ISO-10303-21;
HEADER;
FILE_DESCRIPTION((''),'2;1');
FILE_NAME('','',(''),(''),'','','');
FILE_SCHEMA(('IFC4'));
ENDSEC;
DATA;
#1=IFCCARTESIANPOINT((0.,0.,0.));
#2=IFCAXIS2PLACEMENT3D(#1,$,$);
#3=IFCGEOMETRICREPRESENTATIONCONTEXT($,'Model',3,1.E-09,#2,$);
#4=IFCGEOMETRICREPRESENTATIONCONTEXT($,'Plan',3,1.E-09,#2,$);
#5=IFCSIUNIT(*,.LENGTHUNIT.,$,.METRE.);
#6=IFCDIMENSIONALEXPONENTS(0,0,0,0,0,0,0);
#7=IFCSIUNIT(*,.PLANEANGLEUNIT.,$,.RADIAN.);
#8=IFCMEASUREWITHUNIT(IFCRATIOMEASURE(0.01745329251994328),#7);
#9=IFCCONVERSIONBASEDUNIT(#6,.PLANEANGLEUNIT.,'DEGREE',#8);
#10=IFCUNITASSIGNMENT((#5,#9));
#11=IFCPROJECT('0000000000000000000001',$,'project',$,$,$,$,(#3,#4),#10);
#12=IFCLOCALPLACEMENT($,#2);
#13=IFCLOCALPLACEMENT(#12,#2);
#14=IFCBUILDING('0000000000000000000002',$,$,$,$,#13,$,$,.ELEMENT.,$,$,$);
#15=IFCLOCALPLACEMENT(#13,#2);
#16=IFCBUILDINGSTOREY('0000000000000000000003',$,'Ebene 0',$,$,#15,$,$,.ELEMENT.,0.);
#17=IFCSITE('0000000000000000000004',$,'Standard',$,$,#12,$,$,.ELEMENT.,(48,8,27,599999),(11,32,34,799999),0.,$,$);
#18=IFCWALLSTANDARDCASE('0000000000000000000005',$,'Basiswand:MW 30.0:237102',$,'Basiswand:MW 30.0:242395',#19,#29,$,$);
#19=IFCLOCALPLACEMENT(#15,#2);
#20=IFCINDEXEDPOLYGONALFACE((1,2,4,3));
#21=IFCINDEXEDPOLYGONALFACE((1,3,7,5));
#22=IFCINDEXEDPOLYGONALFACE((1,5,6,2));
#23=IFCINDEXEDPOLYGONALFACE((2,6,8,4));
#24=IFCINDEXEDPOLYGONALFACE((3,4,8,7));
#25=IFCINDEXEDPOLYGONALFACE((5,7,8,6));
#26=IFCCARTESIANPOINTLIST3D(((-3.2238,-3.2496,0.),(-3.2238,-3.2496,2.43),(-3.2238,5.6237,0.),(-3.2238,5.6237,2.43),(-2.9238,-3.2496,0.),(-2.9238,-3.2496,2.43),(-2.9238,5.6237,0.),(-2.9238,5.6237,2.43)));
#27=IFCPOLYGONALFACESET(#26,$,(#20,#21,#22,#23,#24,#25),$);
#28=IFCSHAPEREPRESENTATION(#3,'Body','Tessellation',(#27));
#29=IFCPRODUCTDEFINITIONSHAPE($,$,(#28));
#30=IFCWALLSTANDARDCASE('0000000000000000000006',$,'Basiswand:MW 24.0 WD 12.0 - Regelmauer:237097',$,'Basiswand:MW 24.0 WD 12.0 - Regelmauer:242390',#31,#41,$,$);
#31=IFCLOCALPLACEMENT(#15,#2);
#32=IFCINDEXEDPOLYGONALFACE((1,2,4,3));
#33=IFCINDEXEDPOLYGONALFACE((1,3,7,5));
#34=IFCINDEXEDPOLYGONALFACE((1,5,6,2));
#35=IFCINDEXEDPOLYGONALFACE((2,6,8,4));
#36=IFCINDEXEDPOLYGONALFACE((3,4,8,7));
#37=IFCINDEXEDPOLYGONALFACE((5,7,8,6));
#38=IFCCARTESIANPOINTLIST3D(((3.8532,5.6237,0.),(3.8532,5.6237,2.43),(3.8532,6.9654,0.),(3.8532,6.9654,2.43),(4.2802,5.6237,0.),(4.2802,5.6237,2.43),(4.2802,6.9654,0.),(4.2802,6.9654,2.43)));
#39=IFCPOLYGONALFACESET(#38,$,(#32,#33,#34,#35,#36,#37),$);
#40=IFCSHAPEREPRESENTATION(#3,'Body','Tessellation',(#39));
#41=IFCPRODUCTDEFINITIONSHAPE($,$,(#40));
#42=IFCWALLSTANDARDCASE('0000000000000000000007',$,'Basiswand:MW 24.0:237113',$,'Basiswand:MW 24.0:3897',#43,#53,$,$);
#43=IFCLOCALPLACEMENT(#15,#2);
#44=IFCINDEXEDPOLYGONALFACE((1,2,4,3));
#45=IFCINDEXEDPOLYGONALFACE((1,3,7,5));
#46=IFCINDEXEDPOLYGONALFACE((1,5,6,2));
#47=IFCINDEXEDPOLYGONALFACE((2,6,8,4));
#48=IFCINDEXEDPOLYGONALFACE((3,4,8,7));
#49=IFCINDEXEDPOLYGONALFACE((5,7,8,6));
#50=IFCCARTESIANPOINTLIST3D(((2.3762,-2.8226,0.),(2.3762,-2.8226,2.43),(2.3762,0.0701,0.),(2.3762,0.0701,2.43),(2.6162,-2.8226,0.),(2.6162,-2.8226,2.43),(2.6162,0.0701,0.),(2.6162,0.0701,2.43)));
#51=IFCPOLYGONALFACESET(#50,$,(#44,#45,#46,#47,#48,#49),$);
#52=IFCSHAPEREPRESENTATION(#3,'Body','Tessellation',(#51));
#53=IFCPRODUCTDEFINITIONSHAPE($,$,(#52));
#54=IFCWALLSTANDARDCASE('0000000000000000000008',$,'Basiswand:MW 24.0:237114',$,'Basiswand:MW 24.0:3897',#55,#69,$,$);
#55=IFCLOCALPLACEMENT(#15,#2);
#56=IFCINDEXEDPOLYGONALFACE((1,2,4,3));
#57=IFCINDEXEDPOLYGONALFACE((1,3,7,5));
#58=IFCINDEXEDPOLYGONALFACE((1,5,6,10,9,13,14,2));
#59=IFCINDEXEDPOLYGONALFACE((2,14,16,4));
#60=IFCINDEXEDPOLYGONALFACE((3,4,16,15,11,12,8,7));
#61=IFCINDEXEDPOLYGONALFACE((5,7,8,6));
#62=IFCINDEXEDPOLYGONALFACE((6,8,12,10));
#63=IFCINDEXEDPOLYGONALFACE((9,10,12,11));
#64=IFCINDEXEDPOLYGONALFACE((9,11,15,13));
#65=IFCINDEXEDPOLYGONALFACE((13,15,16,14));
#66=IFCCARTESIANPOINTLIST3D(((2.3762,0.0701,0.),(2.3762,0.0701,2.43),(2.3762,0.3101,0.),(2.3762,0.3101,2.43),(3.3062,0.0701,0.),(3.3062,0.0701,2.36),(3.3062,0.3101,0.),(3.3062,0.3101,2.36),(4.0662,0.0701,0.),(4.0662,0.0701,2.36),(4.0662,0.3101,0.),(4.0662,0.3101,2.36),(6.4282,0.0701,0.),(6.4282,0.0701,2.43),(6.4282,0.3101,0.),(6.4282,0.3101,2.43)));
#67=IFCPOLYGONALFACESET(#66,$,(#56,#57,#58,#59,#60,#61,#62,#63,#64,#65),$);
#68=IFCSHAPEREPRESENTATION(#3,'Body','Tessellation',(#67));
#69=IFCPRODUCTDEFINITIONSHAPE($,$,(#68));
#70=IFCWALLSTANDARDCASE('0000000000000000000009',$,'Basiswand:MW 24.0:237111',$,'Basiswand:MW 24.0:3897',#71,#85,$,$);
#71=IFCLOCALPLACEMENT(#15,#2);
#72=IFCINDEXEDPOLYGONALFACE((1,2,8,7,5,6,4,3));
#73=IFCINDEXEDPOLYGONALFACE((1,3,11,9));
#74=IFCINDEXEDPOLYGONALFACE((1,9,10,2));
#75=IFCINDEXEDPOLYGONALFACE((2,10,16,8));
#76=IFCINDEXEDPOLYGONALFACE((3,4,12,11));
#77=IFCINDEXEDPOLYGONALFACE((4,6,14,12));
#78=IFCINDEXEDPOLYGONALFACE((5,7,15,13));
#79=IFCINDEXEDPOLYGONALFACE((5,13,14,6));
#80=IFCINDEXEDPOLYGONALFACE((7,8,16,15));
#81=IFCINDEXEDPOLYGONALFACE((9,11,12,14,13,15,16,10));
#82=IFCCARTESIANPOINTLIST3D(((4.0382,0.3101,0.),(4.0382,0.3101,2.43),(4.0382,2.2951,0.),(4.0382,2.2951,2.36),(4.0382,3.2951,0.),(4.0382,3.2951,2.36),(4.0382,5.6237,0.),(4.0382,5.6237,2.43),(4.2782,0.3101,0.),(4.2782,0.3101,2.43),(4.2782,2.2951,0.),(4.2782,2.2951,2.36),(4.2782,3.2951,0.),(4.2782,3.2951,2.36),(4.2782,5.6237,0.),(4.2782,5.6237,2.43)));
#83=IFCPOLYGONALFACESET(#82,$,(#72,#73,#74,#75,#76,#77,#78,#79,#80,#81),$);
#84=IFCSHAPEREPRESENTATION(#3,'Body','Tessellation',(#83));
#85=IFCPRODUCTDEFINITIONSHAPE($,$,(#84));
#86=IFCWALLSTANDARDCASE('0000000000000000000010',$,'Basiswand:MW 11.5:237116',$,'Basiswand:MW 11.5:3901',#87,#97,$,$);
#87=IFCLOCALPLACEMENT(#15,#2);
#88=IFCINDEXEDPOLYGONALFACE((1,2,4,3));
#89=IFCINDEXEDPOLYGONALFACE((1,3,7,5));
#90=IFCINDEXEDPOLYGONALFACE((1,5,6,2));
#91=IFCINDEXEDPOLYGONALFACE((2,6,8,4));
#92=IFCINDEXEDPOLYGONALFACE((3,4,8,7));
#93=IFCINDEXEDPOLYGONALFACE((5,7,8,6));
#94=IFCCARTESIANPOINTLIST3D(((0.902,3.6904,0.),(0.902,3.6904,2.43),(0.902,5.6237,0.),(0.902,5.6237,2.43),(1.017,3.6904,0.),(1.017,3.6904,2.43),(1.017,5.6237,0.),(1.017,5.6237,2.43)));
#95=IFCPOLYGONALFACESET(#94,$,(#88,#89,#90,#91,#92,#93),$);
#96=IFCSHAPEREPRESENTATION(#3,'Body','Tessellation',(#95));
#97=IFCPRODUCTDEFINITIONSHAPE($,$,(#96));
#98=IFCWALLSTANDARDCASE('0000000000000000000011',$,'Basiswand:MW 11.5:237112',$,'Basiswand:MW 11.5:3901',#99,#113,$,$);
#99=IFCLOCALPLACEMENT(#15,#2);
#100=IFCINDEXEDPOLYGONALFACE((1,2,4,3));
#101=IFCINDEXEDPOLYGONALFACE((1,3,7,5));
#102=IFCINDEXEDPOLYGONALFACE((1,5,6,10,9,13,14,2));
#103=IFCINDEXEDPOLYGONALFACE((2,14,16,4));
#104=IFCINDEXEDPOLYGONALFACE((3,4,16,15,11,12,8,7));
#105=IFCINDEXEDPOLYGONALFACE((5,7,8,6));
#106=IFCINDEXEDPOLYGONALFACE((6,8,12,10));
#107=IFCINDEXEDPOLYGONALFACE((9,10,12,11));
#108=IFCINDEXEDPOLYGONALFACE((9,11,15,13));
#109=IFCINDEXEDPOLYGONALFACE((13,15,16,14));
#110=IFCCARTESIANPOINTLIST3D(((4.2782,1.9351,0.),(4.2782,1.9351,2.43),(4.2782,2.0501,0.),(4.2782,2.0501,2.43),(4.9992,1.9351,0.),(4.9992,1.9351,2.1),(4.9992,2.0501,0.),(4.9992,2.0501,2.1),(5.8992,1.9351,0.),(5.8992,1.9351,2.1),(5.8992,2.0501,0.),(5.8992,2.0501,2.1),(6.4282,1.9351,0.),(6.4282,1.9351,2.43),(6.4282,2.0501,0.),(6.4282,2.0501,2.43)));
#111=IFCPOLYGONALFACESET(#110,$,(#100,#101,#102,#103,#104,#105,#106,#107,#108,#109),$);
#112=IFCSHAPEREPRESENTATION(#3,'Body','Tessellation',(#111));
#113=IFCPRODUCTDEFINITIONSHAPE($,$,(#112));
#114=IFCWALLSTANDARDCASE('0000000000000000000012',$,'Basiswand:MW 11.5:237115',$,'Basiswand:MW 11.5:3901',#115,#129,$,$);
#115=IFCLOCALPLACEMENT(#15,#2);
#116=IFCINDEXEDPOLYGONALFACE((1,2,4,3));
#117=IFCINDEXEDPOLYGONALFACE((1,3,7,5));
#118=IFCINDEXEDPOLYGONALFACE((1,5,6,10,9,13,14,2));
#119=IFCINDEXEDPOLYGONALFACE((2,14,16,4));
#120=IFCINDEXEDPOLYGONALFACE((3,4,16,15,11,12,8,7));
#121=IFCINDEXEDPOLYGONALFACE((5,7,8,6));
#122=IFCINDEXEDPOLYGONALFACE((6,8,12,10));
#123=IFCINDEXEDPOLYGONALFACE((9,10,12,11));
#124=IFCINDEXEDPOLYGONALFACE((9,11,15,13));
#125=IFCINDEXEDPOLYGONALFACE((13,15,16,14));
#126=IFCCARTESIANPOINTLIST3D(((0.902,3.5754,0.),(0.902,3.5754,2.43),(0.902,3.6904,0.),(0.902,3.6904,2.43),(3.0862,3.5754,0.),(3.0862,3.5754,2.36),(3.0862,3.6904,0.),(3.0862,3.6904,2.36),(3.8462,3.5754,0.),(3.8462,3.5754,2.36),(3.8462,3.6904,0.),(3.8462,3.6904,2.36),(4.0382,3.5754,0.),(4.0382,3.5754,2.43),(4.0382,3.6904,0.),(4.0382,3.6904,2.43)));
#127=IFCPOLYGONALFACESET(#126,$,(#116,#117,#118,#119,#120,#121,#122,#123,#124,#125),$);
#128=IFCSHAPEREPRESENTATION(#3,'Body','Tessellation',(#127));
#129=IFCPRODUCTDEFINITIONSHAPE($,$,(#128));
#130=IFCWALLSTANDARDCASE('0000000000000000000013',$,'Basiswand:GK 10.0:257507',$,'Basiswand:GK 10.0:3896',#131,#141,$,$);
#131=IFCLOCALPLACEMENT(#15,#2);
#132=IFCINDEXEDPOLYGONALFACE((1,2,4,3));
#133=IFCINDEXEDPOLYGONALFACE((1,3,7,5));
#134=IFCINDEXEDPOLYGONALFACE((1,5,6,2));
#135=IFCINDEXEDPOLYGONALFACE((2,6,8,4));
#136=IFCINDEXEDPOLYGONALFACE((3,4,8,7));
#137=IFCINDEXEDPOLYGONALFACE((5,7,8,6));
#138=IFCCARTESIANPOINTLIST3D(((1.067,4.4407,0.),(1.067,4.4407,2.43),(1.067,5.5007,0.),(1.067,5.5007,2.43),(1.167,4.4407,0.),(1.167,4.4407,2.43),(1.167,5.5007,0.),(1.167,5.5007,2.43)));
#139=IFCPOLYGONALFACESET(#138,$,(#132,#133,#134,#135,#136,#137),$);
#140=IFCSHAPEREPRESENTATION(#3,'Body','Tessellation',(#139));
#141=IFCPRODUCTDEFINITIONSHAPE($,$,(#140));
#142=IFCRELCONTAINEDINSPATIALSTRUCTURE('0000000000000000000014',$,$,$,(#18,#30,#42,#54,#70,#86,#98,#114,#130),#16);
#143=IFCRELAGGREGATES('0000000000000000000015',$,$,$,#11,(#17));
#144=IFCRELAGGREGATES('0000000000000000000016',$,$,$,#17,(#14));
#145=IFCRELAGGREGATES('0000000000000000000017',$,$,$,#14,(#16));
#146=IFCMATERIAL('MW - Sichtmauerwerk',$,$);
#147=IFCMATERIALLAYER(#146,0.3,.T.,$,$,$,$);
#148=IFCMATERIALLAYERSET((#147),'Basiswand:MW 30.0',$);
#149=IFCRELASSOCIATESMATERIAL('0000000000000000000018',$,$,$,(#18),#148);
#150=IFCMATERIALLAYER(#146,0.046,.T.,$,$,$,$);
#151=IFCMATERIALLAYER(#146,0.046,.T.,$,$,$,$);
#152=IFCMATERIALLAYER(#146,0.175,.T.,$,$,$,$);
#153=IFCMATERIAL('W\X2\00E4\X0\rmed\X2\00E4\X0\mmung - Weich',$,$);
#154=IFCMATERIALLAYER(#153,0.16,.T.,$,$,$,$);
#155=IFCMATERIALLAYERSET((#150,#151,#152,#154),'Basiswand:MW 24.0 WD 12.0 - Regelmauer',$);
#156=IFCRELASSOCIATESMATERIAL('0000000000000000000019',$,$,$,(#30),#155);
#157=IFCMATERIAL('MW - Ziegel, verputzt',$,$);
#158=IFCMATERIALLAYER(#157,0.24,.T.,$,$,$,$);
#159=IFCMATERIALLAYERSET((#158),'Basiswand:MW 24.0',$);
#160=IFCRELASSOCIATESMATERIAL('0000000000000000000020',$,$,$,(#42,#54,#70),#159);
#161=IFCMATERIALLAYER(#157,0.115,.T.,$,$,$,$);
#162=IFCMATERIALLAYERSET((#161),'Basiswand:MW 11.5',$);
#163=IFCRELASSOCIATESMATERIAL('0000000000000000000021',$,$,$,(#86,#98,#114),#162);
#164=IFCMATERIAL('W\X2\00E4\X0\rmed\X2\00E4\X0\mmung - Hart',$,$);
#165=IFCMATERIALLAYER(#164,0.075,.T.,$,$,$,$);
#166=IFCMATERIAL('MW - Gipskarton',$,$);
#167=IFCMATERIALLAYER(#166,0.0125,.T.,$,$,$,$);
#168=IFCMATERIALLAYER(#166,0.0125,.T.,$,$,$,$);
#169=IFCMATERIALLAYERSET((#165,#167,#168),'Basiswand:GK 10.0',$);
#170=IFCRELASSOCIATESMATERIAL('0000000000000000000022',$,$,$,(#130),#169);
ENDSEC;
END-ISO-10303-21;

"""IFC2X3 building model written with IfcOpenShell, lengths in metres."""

from ifc_helpers import new_model, entity, si_unit, converted_unit, frame, frame_2d, origin, origin_2d_with_axis, place, context, project, spatial, polyline, rectangle, extrude, clip, bounded_halfspace, material, layer, layer_set, layer_usage, element, save


model = new_model("IFC2X3")

# Units and contexts
plan_context = context("Plan", 3, precision=1e-09, world=origin())
model_context = context("Model", 3, precision=1e-09, world=origin())
ifc_project = project(units=[si_unit("LENGTHUNIT", "METRE"), converted_unit("PLANEANGLEUNIT", "DEGREE", entity("IfcRatioMeasure", 0.01745329251994328), si_unit("PLANEANGLEUNIT", "RADIAN"), dimensions=[0, 0, 0, 0, 0, 0, 0])], contexts=[model_context, plan_context])

# Site, building, storey
site_placement = place(None, origin())
site = spatial("IfcSite", under=ifc_project, at=site_placement, Name="Standard", CompositionType="ELEMENT", RefLatitude=(48, 8, 27, 599999), RefLongitude=(11, 32, 34, 799999), RefElevation=0.0)
building_placement = place(site_placement, origin())
building = spatial("IfcBuilding", under=site, at=building_placement, CompositionType="ELEMENT")
storey_placement = place(building_placement, origin())
storey = spatial("IfcBuildingStorey", under=building, at=storey_placement, Name="Ebene 0", CompositionType="ELEMENT", Elevation=0.0)

# Shared definitions
ifc_material_1 = material(Name="MW - Sichtmauerwerk")
ifc_material_2 = material(Name="Wärmedämmung - Hart")

# Walls
ifc_layer_1 = layer(ifc_material_1, 0.3, ventilated=True)
ifc_layer_set_1 = layer_set([ifc_layer_1], Name="Basiswand:MW 30.0")
ifc_layer_usage_1 = layer_usage(ifc_layer_set_1, "AXIS2", "NEGATIVE", 0.15)
wall_1_placement = place(storey_placement, frame((-3.0738, 5.6237, 0.0), z_axis=(0.0, 0.0, 1.0), x_axis=(0.0, -1.0, 0.0)))
element("IfcWallStandardCase", 1, at=wall_1_placement, inside=storey, material=ifc_layer_usage_1, Name="Basiswand:MW 30.0:237102", ObjectType="Basiswand:MW 30.0:242395", context=model_context, shape_type="Clipping", body=[
    clip(extrude(rectangle(XDim=8.8733, YDim=0.3, at=frame_2d((4.4366, 0.0), x_axis=(-1.0, 0.0))), origin(), (0.0, 0.0, 1.0), 2.43), bounded_halfspace(frame((0.0, -0.15, 2.43), z_axis=(0.0, 0.0, -1.0), x_axis=(-1.0, 0.0, 0.0)), True, frame((0.0, -0.15, 2.43)), polyline([(0.0, 0.0), (8.8733, 0.0), (8.8733, 0.3), (8.4463, 0.3), (0.0, 0.3), (0.0, 0.0)]))),
])
ifc_layer_2 = layer(ifc_material_1, 0.046, ventilated=True)
ifc_layer_3 = layer(ifc_material_1, 0.046, ventilated=True)
ifc_layer_4 = layer(ifc_material_1, 0.175, ventilated=True)
ifc_material_3 = material(Name="Wärmedämmung - Weich")
ifc_layer_5 = layer(ifc_material_3, 0.16, ventilated=True)
ifc_layer_set_2 = layer_set([ifc_layer_2, ifc_layer_3, ifc_layer_4, ifc_layer_5], Name="Basiswand:MW 24.0 WD 12.0 - Regelmauer")
ifc_layer_usage_2 = layer_usage(ifc_layer_set_2, "AXIS2", "NEGATIVE", 0.2135)
wall_2_placement = place(storey_placement, frame((4.0667, 6.9654, 0.0), z_axis=(0.0, 0.0, 1.0), x_axis=(0.0, -1.0, 0.0)))
element("IfcWallStandardCase", 2, at=wall_2_placement, inside=storey, material=ifc_layer_usage_2, Name="Basiswand:MW 24.0 WD 12.0 - Regelmauer:237097", ObjectType="Basiswand:MW 24.0 WD 12.0 - Regelmauer:242390", context=model_context, shape_type="Clipping", body=[
    clip(extrude(rectangle(XDim=1.3416, YDim=0.427, at=frame_2d((0.6708, 0.0), x_axis=(-1.0, 0.0))), origin(), (0.0, 0.0, 1.0), 2.43), bounded_halfspace(frame((0.0, -0.2135, 2.43), z_axis=(0.0, 0.0, -1.0), x_axis=(-1.0, 0.0, 0.0)), True, frame((0.0, -0.2135, 2.43)), polyline([(0.0, 0.0), (0.9146, 0.0), (1.3416, 0.0), (1.3416, 0.185), (1.3416, 0.425), (0.427, 0.425), (0.0, 0.425), (0.0, 0.0)]))),
])

# Wall
ifc_material_4 = material(Name="MW - Ziegel, verputzt")
ifc_layer_6 = layer(ifc_material_4, 0.24, ventilated=True)
ifc_layer_set_3 = layer_set([ifc_layer_6], Name="Basiswand:MW 24.0")
ifc_layer_usage_3 = layer_usage(ifc_layer_set_3, "AXIS2", "NEGATIVE", 0.12)
wall_3_placement = place(storey_placement, frame((2.4962, -2.8226, 0.0), z_axis=(0.0, 0.0, 1.0), x_axis=(0.0, 1.0, 0.0)))
element("IfcWallStandardCase", 3, at=wall_3_placement, inside=storey, material=ifc_layer_usage_3, Name="Basiswand:MW 24.0:237113", ObjectType="Basiswand:MW 24.0:3897", context=model_context, shape_type="Clipping", body=[
    clip(extrude(rectangle(XDim=2.8927, YDim=0.24, at=frame_2d((1.4463, 0.0), x_axis=(-1.0, 0.0))), origin(), (0.0, 0.0, 1.0), 2.43), bounded_halfspace(frame((0.0, -0.12, 2.43), z_axis=(0.0, 0.0, -1.0), x_axis=(1.0, 0.0, 0.0)), True, frame((0.0, -0.12, 2.43)), polyline([(0.0, 0.0), (2.8927, 0.0), (2.8927, 0.24), (0.0, 0.24), (0.0, 0.0)]))),
])

# Walls, openings
ifc_layer_usage_4 = layer_usage(ifc_layer_set_3, "AXIS2", "NEGATIVE", 0.12)
wall_4_placement = place(storey_placement, frame((6.4282, 0.1901, 0.0), z_axis=(0.0, 0.0, 1.0), x_axis=(-1.0, 0.0, 0.0)))
wall_4 = element("IfcWallStandardCase", 4, at=wall_4_placement, inside=storey, material=ifc_layer_usage_4, Name="Basiswand:MW 24.0:237114", ObjectType="Basiswand:MW 24.0:3897", context=model_context, shape_type="Clipping", body=[
    clip(extrude(rectangle(XDim=4.052, YDim=0.24, at=frame_2d((2.026, 0.0), x_axis=(-1.0, 0.0))), origin(), (0.0, 0.0, 1.0), 2.43), bounded_halfspace(frame((4.052, 0.12, 2.43), z_axis=(0.0, 0.0, -1.0), x_axis=(0.0, -1.0, 0.0)), True, frame((4.052, 0.12, 2.43)), polyline([(0.0, 0.0), (-0.24, 0.0), (-4.052, 0.0), (-4.052, -0.24), (-1.902, -0.24), (-1.662, -0.24), (0.0, -0.24), (0.0, 0.0)]))),
])
opening_1_placement = place(wall_4_placement, frame((2.362, -0.12, 0.0)))
element("IfcOpeningElement", 5, at=opening_1_placement, cuts=wall_4, ObjectType="Opening", context=model_context, shape_type="SweptSolid", body=[
    extrude(rectangle(XDim=2.36, YDim=0.76, at=frame_2d((1.18, 0.38), x_axis=(1.0, 0.0))), frame((0.0, 0.0, 0.0), z_axis=(0.0, 1.0, 0.0), x_axis=(0.0, 0.0, 1.0)), (0.0, 0.0, 1.0), 0.24),
])
ifc_layer_usage_5 = layer_usage(ifc_layer_set_3, "AXIS2", "NEGATIVE", 0.12)
wall_5_placement = place(storey_placement, frame((4.1582, 0.3101, 0.0), z_axis=(0.0, 0.0, 1.0), x_axis=(0.0, 1.0, 0.0)))
wall_5 = element("IfcWallStandardCase", 6, at=wall_5_placement, inside=storey, material=ifc_layer_usage_5, Name="Basiswand:MW 24.0:237111", ObjectType="Basiswand:MW 24.0:3897", context=model_context, shape_type="Clipping", body=[
    clip(extrude(rectangle(XDim=5.3136, YDim=0.24, at=frame_2d((2.6568, 0.0), x_axis=(-1.0, 0.0))), origin(), (0.0, 0.0, 1.0), 2.43), bounded_halfspace(frame((5.3136, 0.12, 2.43), z_axis=(0.0, 0.0, -1.0), x_axis=(1.0, 0.0, 0.0)), True, frame((5.3136, 0.12, 2.43)), polyline([(0.0, 0.0), (-1.9333, 0.0), (-2.0483, 0.0), (-5.3136, 0.0), (-5.3136, -0.24), (-3.6886, -0.24), (-3.5736, -0.24), (-1.981, -0.24), (0.0, -0.24), (0.0, 0.0)]))),
])
opening_2_placement = place(wall_5_placement, frame((1.985, -0.12, 0.0)))
element("IfcOpeningElement", 7, at=opening_2_placement, cuts=wall_5, ObjectType="Opening", context=model_context, shape_type="SweptSolid", body=[
    extrude(rectangle(XDim=2.36, YDim=1.0, at=frame_2d((1.18, 0.5), x_axis=(1.0, 0.0))), frame((0.0, 0.0, 0.0), z_axis=(0.0, 1.0, 0.0), x_axis=(0.0, 0.0, 1.0)), (0.0, 0.0, 1.0), 0.24),
])

# Wall
ifc_layer_7 = layer(ifc_material_4, 0.115, ventilated=True)
ifc_layer_set_4 = layer_set([ifc_layer_7], Name="Basiswand:MW 11.5")
ifc_layer_usage_6 = layer_usage(ifc_layer_set_4, "AXIS2", "NEGATIVE", 0.0575)
wall_6_placement = place(storey_placement, frame((0.9595, 3.6904, 0.0), z_axis=(0.0, 0.0, 1.0), x_axis=(0.0, 1.0, 0.0)))
element("IfcWallStandardCase", 8, at=wall_6_placement, inside=storey, material=ifc_layer_usage_6, Name="Basiswand:MW 11.5:237116", ObjectType="Basiswand:MW 11.5:3901", context=model_context, shape_type="Clipping", body=[
    clip(extrude(rectangle(XDim=1.9333, YDim=0.115, at=frame_2d((0.9666, 0.0), x_axis=(-1.0, 0.0))), origin(), (0.0, 0.0, 1.0), 2.43), bounded_halfspace(frame((0.0, -0.0575, 2.43), z_axis=(0.0, 0.0, -1.0), x_axis=(1.0, 0.0, 0.0)), True, frame((0.0, -0.0575, 2.43)), polyline([(0.0, 0.0), (0.6503, 0.0), (0.7503, 0.0), (1.9333, 0.0), (1.9333, 0.115), (0.0, 0.115), (0.0, 0.0)]))),
])

# Walls, openings
ifc_layer_usage_7 = layer_usage(ifc_layer_set_4, "AXIS2", "NEGATIVE", 0.0575)
wall_7_placement = place(storey_placement, frame((6.4282, 1.9926, 0.0), z_axis=(0.0, 0.0, 1.0), x_axis=(-1.0, 0.0, 0.0)))
wall_7 = element("IfcWallStandardCase", 9, at=wall_7_placement, inside=storey, material=ifc_layer_usage_7, Name="Basiswand:MW 11.5:237112", ObjectType="Basiswand:MW 11.5:3901", context=model_context, shape_type="Clipping", body=[
    clip(extrude(rectangle(XDim=2.15, YDim=0.115, at=frame_2d((1.075, 0.0), x_axis=(-1.0, 0.0))), origin(), (0.0, 0.0, 1.0), 2.43), bounded_halfspace(frame((0.0, -0.0575, 2.43), z_axis=(0.0, 0.0, -1.0), x_axis=(0.0, -1.0, 0.0)), True, frame((0.0, -0.0575, 2.43)), polyline([(0.0, 0.0), (2.15, 0.0), (2.15, 0.115), (0.0, 0.115), (0.0, 0.0)]))),
])
opening_3_placement = place(wall_7_placement, origin())
element("IfcOpeningElement", 10, at=opening_3_placement, cuts=wall_7, ObjectType="Opening", context=model_context, shape_type="SweptSolid", body=[
    extrude(rectangle(XDim=2.1, YDim=0.9, at=origin_2d_with_axis()), frame((0.979, -1.4665, 1.05), z_axis=(0.0, 1.0, 0.0), x_axis=(0.0, 0.0, 1.0)), (0.0, 0.0, 1.0), 3.048),
])
ifc_layer_usage_8 = layer_usage(ifc_layer_set_4, "AXIS2", "NEGATIVE", 0.0575)
wall_8_placement = place(storey_placement, frame((4.0382, 3.6329, 0.0), z_axis=(0.0, 0.0, 1.0), x_axis=(-1.0, 0.0, 0.0)))
wall_8 = element("IfcWallStandardCase", 11, at=wall_8_placement, inside=storey, material=ifc_layer_usage_8, Name="Basiswand:MW 11.5:237115", ObjectType="Basiswand:MW 11.5:3901", context=model_context, shape_type="Clipping", body=[
    clip(extrude(rectangle(XDim=3.1362, YDim=0.115, at=frame_2d((1.5681, 0.0), x_axis=(-1.0, 0.0))), origin(), (0.0, 0.0, 1.0), 2.43), bounded_halfspace(frame((0.0, -0.0575, 2.43), z_axis=(0.0, 0.0, -1.0), x_axis=(0.0, -1.0, 0.0)), True, frame((0.0, -0.0575, 2.43)), polyline([(0.0, 0.0), (3.0212, 0.0), (3.1362, 0.0), (3.1362, 0.115), (0.0, 0.115), (0.0, 0.0)]))),
])
opening_4_placement = place(wall_8_placement, frame((0.952, 0.0575, 0.0)))
element("IfcOpeningElement", 12, at=opening_4_placement, cuts=wall_8, ObjectType="Opening", context=model_context, shape_type="SweptSolid", body=[
    extrude(rectangle(XDim=2.36, YDim=0.76, at=frame_2d((1.18, 0.38), x_axis=(1.0, 0.0))), frame((0.0, 0.0, 0.0), z_axis=(0.0, -1.0, 0.0), x_axis=(0.0, 0.0, 1.0)), (0.0, 0.0, 1.0), 0.115),
])

# Wall
ifc_layer_8 = layer(ifc_material_2, 0.075, ventilated=True)
ifc_material_5 = material(Name="MW - Gipskarton")
ifc_layer_9 = layer(ifc_material_5, 0.0125, ventilated=True)
ifc_layer_10 = layer(ifc_material_5, 0.0125, ventilated=True)
ifc_layer_set_5 = layer_set([ifc_layer_8, ifc_layer_9, ifc_layer_10], Name="Basiswand:GK 10.0")
ifc_layer_usage_9 = layer_usage(ifc_layer_set_5, "AXIS2", "NEGATIVE", 0.05)
wall_9_placement = place(storey_placement, frame((1.117, 5.5007, 0.0), z_axis=(0.0, 0.0, 1.0), x_axis=(0.0, -1.0, 0.0)))
element("IfcWallStandardCase", 13, at=wall_9_placement, inside=storey, material=ifc_layer_usage_9, Name="Basiswand:GK 10.0:257507", ObjectType="Basiswand:GK 10.0:3896", context=model_context, shape_type="Clipping", body=[
    clip(extrude(rectangle(XDim=1.06, YDim=0.1, at=frame_2d((0.53, 0.0), x_axis=(-1.0, 0.0))), origin(), (0.0, 0.0, 1.0), 2.43), bounded_halfspace(frame((0.0, -0.05, 2.43), z_axis=(0.0, 0.0, -1.0), x_axis=(-1.0, 0.0, 0.0)), True, frame((0.0, -0.05, 2.43)), polyline([(0.0, 0.0), (1.06, 0.0), (1.06, 0.1), (0.1, 0.1), (0.0, 0.1), (0.0, 0.0)]))),
])

save(model, "model.ifc")
